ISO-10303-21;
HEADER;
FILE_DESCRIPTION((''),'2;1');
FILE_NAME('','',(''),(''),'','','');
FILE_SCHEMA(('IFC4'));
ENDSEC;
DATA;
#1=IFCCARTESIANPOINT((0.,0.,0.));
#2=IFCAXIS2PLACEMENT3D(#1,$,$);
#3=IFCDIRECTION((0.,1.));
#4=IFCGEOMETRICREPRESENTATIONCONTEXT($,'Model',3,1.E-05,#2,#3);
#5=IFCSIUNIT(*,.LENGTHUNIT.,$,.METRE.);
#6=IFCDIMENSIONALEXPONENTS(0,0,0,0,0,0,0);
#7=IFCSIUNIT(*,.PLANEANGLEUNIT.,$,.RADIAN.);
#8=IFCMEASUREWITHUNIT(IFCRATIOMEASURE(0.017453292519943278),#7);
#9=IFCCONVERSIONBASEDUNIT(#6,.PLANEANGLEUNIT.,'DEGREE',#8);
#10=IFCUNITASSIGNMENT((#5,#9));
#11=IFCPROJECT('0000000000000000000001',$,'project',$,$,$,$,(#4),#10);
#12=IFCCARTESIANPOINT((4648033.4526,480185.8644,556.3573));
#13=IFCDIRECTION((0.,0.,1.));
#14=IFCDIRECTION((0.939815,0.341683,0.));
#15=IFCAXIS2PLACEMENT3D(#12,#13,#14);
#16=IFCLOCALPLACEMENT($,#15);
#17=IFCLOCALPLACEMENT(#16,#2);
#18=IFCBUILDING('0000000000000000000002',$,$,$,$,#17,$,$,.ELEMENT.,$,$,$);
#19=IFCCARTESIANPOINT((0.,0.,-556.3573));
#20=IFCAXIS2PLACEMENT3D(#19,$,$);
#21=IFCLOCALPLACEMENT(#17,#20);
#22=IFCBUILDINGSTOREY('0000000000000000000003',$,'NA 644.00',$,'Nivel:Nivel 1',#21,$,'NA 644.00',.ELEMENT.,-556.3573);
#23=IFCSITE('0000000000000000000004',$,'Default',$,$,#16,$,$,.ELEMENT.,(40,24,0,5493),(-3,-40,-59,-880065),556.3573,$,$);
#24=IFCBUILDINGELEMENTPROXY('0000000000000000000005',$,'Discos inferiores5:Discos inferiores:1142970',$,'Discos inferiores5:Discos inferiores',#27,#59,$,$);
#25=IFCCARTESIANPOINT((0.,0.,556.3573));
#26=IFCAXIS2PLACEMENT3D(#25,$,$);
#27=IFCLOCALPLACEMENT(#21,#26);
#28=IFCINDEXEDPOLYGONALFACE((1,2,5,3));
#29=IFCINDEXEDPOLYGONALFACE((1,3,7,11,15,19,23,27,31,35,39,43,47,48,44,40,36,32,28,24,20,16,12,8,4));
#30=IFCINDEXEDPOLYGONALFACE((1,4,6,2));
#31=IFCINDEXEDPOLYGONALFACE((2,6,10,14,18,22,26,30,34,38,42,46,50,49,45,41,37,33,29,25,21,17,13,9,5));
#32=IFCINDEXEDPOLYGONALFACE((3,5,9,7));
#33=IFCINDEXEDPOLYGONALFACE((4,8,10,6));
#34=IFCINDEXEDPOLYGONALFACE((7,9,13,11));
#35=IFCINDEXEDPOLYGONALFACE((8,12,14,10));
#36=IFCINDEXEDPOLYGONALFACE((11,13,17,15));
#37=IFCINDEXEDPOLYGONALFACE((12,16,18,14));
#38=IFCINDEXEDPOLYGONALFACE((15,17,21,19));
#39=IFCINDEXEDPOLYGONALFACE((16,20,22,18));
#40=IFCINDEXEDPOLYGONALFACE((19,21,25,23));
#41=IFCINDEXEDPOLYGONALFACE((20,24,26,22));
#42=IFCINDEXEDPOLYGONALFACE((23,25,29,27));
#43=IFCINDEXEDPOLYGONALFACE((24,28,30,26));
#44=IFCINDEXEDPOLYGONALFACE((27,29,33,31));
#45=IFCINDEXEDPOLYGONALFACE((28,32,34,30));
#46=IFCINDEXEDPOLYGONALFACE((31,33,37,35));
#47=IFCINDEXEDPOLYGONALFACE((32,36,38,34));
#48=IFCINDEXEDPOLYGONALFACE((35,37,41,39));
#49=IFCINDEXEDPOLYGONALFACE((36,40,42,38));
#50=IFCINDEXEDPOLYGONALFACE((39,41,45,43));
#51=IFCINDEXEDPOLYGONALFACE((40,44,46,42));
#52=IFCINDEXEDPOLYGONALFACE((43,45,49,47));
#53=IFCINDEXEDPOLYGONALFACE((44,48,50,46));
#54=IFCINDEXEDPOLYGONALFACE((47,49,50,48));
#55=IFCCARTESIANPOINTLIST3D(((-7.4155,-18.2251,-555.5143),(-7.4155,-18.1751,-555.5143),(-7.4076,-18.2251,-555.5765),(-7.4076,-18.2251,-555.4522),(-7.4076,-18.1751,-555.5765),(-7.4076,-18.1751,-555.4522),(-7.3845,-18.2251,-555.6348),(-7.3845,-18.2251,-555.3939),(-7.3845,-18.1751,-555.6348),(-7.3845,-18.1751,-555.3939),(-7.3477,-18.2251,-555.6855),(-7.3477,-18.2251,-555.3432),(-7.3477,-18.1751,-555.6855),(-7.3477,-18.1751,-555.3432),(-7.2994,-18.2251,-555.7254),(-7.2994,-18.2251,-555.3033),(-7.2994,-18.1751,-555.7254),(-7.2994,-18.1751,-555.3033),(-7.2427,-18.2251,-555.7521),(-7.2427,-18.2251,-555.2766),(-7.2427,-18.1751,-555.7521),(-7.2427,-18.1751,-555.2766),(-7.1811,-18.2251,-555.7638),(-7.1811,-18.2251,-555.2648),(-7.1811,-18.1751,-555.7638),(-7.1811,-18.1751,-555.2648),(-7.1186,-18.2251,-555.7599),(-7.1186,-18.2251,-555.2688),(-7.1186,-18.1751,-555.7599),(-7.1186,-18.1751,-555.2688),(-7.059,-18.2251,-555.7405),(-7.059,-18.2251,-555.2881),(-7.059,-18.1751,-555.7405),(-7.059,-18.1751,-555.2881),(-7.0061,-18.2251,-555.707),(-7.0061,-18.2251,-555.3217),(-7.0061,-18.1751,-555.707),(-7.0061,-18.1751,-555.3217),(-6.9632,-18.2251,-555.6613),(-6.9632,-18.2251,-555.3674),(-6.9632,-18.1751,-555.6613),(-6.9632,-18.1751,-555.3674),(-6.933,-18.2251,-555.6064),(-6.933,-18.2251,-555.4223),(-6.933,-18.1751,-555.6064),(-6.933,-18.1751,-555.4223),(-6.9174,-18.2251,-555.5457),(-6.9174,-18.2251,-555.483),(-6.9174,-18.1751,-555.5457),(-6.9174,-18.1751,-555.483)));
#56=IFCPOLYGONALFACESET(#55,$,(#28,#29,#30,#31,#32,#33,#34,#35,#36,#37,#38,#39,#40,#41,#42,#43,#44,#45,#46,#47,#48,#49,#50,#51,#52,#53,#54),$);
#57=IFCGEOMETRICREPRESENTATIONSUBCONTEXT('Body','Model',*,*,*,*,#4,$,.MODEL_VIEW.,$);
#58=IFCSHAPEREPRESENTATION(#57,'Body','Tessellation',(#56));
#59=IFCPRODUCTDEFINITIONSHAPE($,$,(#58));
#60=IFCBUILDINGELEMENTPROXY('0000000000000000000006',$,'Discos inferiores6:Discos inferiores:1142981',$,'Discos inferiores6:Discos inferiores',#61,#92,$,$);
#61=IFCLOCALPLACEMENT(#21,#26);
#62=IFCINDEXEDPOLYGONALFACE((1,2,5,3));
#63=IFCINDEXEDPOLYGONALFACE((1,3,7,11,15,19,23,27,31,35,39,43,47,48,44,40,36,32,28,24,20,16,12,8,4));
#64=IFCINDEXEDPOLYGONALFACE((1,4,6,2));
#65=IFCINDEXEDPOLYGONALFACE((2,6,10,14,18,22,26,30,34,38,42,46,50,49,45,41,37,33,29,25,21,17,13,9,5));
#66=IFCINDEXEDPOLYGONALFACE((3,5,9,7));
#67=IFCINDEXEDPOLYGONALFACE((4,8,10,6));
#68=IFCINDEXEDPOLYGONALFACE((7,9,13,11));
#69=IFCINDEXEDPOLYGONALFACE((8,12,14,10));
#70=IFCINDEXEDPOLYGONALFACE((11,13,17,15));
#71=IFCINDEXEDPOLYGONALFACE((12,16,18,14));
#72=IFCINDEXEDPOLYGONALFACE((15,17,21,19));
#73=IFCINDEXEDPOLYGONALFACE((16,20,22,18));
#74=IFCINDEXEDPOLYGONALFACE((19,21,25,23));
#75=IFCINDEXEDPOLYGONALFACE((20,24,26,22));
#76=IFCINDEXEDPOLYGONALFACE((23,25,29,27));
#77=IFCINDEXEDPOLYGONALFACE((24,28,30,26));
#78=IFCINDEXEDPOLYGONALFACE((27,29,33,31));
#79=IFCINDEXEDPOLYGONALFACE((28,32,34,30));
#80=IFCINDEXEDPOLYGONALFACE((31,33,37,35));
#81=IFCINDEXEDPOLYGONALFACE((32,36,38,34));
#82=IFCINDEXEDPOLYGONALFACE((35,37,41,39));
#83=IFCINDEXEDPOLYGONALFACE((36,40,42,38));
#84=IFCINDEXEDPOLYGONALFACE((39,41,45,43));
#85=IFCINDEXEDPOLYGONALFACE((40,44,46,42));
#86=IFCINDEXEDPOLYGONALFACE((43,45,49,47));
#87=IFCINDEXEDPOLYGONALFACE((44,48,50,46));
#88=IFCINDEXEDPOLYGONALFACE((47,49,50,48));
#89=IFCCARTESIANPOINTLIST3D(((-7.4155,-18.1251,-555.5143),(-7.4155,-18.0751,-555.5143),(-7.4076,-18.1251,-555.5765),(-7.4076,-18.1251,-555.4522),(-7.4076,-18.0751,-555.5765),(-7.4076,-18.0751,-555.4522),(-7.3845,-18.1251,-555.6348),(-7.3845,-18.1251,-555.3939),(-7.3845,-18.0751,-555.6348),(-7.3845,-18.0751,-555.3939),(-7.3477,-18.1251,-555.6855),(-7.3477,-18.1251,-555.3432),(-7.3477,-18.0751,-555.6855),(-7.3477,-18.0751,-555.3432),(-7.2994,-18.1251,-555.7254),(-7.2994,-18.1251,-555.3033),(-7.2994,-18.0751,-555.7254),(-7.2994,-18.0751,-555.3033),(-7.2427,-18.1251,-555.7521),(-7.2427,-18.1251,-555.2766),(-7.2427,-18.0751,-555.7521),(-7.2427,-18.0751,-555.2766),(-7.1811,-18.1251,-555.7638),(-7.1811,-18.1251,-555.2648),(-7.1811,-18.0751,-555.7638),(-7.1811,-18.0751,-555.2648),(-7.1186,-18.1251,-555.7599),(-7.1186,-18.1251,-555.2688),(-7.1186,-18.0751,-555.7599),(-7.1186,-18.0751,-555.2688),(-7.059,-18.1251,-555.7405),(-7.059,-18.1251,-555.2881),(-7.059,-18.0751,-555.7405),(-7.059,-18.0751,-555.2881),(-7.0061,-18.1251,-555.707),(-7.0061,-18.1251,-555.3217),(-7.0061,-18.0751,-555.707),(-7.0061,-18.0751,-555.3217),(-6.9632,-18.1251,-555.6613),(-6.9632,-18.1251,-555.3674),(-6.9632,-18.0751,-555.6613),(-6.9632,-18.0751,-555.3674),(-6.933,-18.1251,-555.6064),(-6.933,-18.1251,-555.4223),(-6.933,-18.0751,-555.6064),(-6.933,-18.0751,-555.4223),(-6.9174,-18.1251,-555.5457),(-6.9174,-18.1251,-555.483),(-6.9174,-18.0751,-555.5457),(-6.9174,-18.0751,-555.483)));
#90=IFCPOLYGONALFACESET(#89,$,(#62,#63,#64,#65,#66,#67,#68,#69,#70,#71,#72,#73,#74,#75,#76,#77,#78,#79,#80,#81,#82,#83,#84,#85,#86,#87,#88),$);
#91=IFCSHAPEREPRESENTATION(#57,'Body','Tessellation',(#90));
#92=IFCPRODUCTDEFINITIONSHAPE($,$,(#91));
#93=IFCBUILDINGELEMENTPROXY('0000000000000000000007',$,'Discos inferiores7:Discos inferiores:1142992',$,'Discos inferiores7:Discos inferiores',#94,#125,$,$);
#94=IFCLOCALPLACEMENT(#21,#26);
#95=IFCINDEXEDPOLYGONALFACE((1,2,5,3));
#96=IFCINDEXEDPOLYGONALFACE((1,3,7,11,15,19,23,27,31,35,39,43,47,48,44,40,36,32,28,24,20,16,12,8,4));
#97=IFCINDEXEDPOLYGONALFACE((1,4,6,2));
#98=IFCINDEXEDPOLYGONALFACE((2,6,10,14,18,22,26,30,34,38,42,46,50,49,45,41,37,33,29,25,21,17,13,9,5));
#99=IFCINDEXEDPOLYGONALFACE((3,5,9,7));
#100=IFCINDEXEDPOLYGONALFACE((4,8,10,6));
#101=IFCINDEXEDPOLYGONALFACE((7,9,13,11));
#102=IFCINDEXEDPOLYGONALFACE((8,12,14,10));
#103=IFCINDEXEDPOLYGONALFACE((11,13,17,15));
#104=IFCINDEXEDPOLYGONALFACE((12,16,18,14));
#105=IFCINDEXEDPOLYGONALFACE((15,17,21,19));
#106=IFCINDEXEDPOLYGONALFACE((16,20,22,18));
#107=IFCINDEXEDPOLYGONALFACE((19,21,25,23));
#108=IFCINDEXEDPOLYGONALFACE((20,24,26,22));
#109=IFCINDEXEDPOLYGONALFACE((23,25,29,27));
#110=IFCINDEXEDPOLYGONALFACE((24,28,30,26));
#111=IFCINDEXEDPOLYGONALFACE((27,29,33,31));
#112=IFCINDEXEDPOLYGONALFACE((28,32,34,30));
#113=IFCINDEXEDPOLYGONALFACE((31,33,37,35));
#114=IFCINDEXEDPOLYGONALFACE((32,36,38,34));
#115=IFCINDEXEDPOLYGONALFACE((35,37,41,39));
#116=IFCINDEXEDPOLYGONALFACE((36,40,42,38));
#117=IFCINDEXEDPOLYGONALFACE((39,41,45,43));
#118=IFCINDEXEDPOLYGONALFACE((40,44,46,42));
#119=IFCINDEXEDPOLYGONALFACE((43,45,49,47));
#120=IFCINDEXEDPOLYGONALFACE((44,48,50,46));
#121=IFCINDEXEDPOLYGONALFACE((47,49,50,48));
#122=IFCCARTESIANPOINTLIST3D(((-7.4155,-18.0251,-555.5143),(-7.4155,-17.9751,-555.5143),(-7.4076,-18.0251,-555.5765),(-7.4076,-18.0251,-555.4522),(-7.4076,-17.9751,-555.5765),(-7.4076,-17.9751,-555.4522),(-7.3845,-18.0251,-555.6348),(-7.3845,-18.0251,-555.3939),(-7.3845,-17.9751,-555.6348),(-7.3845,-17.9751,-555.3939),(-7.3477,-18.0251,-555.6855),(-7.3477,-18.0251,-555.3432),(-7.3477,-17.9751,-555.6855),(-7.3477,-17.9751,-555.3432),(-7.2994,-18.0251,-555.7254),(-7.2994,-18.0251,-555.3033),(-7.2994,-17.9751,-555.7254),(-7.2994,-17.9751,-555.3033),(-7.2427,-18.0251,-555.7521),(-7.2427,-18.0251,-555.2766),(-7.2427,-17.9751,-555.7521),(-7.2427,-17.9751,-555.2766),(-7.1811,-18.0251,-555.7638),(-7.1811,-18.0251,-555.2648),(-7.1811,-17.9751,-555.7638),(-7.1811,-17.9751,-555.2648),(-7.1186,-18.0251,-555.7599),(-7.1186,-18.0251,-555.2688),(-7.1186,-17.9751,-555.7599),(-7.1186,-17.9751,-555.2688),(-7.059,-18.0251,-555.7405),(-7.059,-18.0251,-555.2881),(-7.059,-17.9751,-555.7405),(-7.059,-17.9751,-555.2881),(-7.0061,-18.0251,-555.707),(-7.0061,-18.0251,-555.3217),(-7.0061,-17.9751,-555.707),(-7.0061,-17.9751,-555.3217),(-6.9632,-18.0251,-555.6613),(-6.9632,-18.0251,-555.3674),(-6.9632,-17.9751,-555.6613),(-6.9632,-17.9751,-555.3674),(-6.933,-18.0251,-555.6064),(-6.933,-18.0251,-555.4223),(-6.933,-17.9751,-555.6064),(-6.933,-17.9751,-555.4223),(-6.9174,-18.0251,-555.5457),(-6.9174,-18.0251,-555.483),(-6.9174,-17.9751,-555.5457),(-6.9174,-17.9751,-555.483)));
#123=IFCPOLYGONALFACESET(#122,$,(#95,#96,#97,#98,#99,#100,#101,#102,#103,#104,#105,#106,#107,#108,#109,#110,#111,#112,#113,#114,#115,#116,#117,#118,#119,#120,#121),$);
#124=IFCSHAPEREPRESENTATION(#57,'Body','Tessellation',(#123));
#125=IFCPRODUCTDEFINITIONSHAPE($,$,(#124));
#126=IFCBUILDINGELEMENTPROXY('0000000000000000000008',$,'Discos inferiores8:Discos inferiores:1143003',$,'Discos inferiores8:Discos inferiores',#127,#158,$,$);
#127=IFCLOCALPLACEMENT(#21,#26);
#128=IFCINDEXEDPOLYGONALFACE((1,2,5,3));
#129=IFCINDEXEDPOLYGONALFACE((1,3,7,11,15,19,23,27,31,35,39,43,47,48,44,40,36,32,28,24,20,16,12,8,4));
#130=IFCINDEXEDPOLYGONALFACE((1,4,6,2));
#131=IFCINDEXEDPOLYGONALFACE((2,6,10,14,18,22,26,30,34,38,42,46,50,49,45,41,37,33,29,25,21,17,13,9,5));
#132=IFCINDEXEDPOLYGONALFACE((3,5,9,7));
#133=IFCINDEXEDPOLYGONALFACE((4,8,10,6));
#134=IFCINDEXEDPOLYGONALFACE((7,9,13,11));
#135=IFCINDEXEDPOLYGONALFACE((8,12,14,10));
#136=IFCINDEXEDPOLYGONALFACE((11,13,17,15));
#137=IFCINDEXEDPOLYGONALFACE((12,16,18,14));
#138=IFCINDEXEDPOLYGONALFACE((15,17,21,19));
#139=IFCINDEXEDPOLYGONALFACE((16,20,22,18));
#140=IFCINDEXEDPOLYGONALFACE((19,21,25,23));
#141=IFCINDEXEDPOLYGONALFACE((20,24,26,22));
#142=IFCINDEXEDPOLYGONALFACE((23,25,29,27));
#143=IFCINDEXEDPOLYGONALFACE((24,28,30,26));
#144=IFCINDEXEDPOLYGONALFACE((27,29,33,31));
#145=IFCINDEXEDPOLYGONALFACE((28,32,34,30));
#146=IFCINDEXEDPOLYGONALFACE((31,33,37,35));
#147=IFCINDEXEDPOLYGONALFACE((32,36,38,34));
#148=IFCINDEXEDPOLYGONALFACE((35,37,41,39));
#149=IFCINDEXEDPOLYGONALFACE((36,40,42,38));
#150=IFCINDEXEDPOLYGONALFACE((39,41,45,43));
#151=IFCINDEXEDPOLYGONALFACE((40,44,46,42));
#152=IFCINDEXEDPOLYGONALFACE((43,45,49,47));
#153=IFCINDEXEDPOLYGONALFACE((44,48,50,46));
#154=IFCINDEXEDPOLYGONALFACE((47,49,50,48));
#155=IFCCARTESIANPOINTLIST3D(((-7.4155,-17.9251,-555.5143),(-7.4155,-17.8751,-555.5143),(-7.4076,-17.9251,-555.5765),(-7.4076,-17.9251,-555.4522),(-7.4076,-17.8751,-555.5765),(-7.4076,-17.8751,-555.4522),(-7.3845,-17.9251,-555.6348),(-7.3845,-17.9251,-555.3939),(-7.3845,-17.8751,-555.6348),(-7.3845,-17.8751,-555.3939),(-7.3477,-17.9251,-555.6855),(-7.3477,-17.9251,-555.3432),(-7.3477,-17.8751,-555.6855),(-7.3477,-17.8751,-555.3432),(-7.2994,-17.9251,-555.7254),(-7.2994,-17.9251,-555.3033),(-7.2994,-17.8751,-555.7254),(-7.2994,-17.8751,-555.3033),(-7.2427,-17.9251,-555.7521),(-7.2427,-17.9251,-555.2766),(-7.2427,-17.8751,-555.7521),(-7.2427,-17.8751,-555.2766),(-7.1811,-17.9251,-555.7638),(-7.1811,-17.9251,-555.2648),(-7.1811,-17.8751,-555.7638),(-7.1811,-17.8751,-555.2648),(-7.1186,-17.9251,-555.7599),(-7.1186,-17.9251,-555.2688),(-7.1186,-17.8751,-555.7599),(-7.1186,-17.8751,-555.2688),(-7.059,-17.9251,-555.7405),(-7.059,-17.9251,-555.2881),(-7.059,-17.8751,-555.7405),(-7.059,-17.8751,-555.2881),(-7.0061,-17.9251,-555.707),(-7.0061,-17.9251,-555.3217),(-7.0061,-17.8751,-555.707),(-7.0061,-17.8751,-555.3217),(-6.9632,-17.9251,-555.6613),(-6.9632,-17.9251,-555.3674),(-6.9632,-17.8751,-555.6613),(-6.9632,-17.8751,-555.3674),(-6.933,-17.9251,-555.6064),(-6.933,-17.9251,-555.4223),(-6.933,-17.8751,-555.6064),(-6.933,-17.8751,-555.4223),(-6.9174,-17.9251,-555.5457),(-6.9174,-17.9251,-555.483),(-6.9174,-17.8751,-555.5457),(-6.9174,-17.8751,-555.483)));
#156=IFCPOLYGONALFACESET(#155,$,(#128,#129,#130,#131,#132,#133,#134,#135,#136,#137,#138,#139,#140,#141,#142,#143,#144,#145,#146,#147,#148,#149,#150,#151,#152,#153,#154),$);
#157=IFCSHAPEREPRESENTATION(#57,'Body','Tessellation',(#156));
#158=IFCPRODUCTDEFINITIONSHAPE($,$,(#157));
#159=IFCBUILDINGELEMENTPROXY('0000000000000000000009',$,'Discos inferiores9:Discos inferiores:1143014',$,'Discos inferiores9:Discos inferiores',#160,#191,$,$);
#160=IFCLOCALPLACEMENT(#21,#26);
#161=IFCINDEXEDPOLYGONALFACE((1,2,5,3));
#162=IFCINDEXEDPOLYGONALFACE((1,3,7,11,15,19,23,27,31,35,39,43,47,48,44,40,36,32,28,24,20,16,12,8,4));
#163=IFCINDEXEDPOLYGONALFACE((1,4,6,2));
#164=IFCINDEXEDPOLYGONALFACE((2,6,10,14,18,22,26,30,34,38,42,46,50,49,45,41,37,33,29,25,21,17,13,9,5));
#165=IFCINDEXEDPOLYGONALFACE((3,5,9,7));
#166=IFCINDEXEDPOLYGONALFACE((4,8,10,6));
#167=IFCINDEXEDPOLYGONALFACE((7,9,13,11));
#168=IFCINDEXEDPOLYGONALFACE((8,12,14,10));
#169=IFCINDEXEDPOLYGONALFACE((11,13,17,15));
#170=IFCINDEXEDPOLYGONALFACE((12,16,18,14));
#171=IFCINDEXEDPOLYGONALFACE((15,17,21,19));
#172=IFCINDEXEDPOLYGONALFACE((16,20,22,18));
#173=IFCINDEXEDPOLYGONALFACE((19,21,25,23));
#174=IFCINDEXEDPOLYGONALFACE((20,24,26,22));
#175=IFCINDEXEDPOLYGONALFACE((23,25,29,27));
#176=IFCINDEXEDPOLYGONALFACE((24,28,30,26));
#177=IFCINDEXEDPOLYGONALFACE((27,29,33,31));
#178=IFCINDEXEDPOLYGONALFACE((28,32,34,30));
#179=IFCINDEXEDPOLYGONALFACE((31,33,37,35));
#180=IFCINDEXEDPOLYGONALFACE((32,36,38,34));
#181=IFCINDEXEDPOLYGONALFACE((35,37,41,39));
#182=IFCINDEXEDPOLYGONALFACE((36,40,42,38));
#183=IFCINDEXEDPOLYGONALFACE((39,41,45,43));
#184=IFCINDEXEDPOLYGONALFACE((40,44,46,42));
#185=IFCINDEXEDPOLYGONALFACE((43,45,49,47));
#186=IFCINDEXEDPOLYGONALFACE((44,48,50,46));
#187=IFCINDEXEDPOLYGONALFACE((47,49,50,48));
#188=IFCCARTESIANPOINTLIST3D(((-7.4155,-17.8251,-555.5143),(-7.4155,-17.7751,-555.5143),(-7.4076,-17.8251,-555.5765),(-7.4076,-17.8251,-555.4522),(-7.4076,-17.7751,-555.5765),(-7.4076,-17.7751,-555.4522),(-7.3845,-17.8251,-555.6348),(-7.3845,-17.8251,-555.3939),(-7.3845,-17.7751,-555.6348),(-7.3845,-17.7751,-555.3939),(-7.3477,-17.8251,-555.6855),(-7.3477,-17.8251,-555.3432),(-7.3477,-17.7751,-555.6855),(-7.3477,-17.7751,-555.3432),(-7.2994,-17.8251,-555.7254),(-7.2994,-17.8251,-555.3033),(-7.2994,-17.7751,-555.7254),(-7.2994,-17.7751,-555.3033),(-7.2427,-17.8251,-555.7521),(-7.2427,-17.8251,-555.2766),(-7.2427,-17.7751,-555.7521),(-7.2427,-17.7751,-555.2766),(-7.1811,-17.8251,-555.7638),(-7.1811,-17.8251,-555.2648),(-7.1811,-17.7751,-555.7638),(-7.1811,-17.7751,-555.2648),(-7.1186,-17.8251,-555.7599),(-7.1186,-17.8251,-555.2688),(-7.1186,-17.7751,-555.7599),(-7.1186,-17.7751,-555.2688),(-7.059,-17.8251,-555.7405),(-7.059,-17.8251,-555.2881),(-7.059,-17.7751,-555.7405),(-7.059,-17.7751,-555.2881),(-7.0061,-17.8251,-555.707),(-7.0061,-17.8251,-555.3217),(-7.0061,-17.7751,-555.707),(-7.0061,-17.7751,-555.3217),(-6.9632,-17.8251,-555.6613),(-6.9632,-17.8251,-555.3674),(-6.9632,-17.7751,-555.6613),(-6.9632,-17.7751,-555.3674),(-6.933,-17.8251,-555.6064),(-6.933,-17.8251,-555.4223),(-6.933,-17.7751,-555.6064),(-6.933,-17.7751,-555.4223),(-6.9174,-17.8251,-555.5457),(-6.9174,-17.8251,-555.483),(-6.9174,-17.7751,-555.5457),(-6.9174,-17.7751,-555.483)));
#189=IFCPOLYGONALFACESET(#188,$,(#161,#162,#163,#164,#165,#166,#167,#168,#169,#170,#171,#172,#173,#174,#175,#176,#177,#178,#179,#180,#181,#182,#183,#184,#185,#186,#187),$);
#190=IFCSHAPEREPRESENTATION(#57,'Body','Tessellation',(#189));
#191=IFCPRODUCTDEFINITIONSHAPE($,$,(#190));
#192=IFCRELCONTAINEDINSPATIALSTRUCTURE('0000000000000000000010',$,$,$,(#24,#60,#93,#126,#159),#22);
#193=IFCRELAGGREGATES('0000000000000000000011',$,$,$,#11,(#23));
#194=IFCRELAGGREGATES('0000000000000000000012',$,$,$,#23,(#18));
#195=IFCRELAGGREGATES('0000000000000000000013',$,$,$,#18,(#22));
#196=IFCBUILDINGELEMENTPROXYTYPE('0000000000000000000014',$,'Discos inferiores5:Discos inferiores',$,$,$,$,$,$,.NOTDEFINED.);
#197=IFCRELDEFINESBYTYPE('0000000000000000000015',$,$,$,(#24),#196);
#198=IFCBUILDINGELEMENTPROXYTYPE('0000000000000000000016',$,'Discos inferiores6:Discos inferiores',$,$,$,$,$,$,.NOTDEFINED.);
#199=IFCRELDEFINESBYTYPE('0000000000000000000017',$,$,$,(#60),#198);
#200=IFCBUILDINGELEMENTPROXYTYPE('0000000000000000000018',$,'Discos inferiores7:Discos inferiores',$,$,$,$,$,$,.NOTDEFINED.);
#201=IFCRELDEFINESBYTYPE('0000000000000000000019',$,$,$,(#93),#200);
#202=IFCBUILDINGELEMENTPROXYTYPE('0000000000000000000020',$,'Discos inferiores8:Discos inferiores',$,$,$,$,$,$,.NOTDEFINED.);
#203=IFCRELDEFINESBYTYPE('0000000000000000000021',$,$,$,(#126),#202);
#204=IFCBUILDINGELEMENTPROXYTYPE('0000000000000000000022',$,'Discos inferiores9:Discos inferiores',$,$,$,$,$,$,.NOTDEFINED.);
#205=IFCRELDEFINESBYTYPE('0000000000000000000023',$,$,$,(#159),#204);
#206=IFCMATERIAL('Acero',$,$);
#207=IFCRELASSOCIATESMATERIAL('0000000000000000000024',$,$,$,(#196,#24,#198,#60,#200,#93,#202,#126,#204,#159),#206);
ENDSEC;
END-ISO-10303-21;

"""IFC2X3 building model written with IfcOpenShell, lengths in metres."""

from ifc_helpers import new_model, entity, si_unit, converted_unit, direction, frame, origin, origin_2d_with_axis, place, context, subcontext, project, spatial, circle, extrude, source, transform, mapped, material, type_object, type_shapes, element, save


model = new_model("IFC2X3")

# Units and contexts
model_context = context("Model", 3, precision=1e-05, world=origin(), true_north=direction((0.0, 1.0)))
body_context = subcontext(model_context, "Body", "Model", "MODEL_VIEW")
ifc_project = project(units=[si_unit("LENGTHUNIT", "METRE"), converted_unit("PLANEANGLEUNIT", "DEGREE", entity("IfcRatioMeasure", 0.017453292519943278), si_unit("PLANEANGLEUNIT", "RADIAN"), dimensions=[0, 0, 0, 0, 0, 0, 0])], contexts=[model_context])

# Site, building, storey
site_placement = place(None, frame((4648033.4526, 480185.8644, 556.3573), z_axis=(0.0, 0.0, 1.0), x_axis=(0.939815, 0.341683, 0.0)))
site = spatial("IfcSite", under=ifc_project, at=site_placement, Name="Default", CompositionType="ELEMENT", RefLatitude=(40, 24, 0, 5493), RefLongitude=(-3, -40, -59, -880065), RefElevation=556.3573)
building_placement = place(site_placement, origin())
building = spatial("IfcBuilding", under=site, at=building_placement, CompositionType="ELEMENT")
storey_placement = place(building_placement, frame((0.0, 0.0, -556.3573)))
storey = spatial("IfcBuildingStorey", under=building, at=storey_placement, Name="NA 644.00", ObjectType="Nivel:Nivel 1", LongName="NA 644.00", CompositionType="ELEMENT", Elevation=-556.3573)

# Building element proxies
ifc_material_1 = material(Name="Acero")
building_element_proxy_type_1 = type_object("IfcBuildingElementProxyType", Name="Discos inferiores5:Discos inferiores", PredefinedType="NOTDEFINED", material=ifc_material_1)
shared_shape_1 = source(origin(), body_context, "Body", "SweptSolid", [
    extrude(circle(Radius=0.25, at=origin_2d_with_axis()), frame((-7.1655, -18.2251, -555.5143), z_axis=(0.0, 1.0, 0.0), x_axis=(-1.0, 0.0, 0.0)), (0.0, 0.0, 1.0), 0.05),
])
type_shapes(building_element_proxy_type_1, [shared_shape_1])
proxy_1_placement = place(storey_placement, frame((0.0, 0.0, 556.3573)))
element("IfcBuildingElementProxy", 1, at=proxy_1_placement, inside=storey, type_object=building_element_proxy_type_1, material=ifc_material_1, Name="Discos inferiores5:Discos inferiores:1142970", ObjectType="Discos inferiores5:Discos inferiores", context=body_context, shape_type="MappedRepresentation", body=[
    mapped(shared_shape_1, transform((0.0, 0.0, 0.0), scale=1.0)),
])
building_element_proxy_type_2 = type_object("IfcBuildingElementProxyType", Name="Discos inferiores6:Discos inferiores", PredefinedType="NOTDEFINED", material=ifc_material_1)
shared_shape_2 = source(origin(), body_context, "Body", "SweptSolid", [
    extrude(circle(Radius=0.25, at=origin_2d_with_axis()), frame((-7.1655, -18.1251, -555.5143), z_axis=(0.0, 1.0, 0.0), x_axis=(-1.0, 0.0, 0.0)), (0.0, 0.0, 1.0), 0.05),
])
type_shapes(building_element_proxy_type_2, [shared_shape_2])
proxy_2_placement = place(storey_placement, frame((0.0, 0.0, 556.3573)))
element("IfcBuildingElementProxy", 2, at=proxy_2_placement, inside=storey, type_object=building_element_proxy_type_2, material=ifc_material_1, Name="Discos inferiores6:Discos inferiores:1142981", ObjectType="Discos inferiores6:Discos inferiores", context=body_context, shape_type="MappedRepresentation", body=[
    mapped(shared_shape_2, transform((0.0, 0.0, 0.0), scale=1.0)),
])
building_element_proxy_type_3 = type_object("IfcBuildingElementProxyType", Name="Discos inferiores7:Discos inferiores", PredefinedType="NOTDEFINED", material=ifc_material_1)
shared_shape_3 = source(origin(), body_context, "Body", "SweptSolid", [
    extrude(circle(Radius=0.25, at=origin_2d_with_axis()), frame((-7.1655, -18.0251, -555.5143), z_axis=(0.0, 1.0, 0.0), x_axis=(-1.0, 0.0, 0.0)), (0.0, 0.0, 1.0), 0.05),
])
type_shapes(building_element_proxy_type_3, [shared_shape_3])
proxy_3_placement = place(storey_placement, frame((0.0, 0.0, 556.3573)))
element("IfcBuildingElementProxy", 3, at=proxy_3_placement, inside=storey, type_object=building_element_proxy_type_3, material=ifc_material_1, Name="Discos inferiores7:Discos inferiores:1142992", ObjectType="Discos inferiores7:Discos inferiores", context=body_context, shape_type="MappedRepresentation", body=[
    mapped(shared_shape_3, transform((0.0, 0.0, 0.0), scale=1.0)),
])
building_element_proxy_type_4 = type_object("IfcBuildingElementProxyType", Name="Discos inferiores8:Discos inferiores", PredefinedType="NOTDEFINED", material=ifc_material_1)
shared_shape_4 = source(origin(), body_context, "Body", "SweptSolid", [
    extrude(circle(Radius=0.25, at=origin_2d_with_axis()), frame((-7.1655, -17.9251, -555.5143), z_axis=(0.0, 1.0, 0.0), x_axis=(-1.0, 0.0, 0.0)), (0.0, 0.0, 1.0), 0.05),
])
type_shapes(building_element_proxy_type_4, [shared_shape_4])
proxy_4_placement = place(storey_placement, frame((0.0, 0.0, 556.3573)))
element("IfcBuildingElementProxy", 4, at=proxy_4_placement, inside=storey, type_object=building_element_proxy_type_4, material=ifc_material_1, Name="Discos inferiores8:Discos inferiores:1143003", ObjectType="Discos inferiores8:Discos inferiores", context=body_context, shape_type="MappedRepresentation", body=[
    mapped(shared_shape_4, transform((0.0, 0.0, 0.0), scale=1.0)),
])
building_element_proxy_type_5 = type_object("IfcBuildingElementProxyType", Name="Discos inferiores9:Discos inferiores", PredefinedType="NOTDEFINED", material=ifc_material_1)
shared_shape_5 = source(origin(), body_context, "Body", "SweptSolid", [
    extrude(circle(Radius=0.25, at=origin_2d_with_axis()), frame((-7.1655, -17.8251, -555.5143), z_axis=(0.0, 1.0, 0.0), x_axis=(-1.0, 0.0, 0.0)), (0.0, 0.0, 1.0), 0.05),
])
type_shapes(building_element_proxy_type_5, [shared_shape_5])
proxy_5_placement = place(storey_placement, frame((0.0, 0.0, 556.3573)))
element("IfcBuildingElementProxy", 5, at=proxy_5_placement, inside=storey, type_object=building_element_proxy_type_5, material=ifc_material_1, Name="Discos inferiores9:Discos inferiores:1143014", ObjectType="Discos inferiores9:Discos inferiores", context=body_context, shape_type="MappedRepresentation", body=[
    mapped(shared_shape_5, transform((0.0, 0.0, 0.0), scale=1.0)),
])

save(model, "model.ifc")
